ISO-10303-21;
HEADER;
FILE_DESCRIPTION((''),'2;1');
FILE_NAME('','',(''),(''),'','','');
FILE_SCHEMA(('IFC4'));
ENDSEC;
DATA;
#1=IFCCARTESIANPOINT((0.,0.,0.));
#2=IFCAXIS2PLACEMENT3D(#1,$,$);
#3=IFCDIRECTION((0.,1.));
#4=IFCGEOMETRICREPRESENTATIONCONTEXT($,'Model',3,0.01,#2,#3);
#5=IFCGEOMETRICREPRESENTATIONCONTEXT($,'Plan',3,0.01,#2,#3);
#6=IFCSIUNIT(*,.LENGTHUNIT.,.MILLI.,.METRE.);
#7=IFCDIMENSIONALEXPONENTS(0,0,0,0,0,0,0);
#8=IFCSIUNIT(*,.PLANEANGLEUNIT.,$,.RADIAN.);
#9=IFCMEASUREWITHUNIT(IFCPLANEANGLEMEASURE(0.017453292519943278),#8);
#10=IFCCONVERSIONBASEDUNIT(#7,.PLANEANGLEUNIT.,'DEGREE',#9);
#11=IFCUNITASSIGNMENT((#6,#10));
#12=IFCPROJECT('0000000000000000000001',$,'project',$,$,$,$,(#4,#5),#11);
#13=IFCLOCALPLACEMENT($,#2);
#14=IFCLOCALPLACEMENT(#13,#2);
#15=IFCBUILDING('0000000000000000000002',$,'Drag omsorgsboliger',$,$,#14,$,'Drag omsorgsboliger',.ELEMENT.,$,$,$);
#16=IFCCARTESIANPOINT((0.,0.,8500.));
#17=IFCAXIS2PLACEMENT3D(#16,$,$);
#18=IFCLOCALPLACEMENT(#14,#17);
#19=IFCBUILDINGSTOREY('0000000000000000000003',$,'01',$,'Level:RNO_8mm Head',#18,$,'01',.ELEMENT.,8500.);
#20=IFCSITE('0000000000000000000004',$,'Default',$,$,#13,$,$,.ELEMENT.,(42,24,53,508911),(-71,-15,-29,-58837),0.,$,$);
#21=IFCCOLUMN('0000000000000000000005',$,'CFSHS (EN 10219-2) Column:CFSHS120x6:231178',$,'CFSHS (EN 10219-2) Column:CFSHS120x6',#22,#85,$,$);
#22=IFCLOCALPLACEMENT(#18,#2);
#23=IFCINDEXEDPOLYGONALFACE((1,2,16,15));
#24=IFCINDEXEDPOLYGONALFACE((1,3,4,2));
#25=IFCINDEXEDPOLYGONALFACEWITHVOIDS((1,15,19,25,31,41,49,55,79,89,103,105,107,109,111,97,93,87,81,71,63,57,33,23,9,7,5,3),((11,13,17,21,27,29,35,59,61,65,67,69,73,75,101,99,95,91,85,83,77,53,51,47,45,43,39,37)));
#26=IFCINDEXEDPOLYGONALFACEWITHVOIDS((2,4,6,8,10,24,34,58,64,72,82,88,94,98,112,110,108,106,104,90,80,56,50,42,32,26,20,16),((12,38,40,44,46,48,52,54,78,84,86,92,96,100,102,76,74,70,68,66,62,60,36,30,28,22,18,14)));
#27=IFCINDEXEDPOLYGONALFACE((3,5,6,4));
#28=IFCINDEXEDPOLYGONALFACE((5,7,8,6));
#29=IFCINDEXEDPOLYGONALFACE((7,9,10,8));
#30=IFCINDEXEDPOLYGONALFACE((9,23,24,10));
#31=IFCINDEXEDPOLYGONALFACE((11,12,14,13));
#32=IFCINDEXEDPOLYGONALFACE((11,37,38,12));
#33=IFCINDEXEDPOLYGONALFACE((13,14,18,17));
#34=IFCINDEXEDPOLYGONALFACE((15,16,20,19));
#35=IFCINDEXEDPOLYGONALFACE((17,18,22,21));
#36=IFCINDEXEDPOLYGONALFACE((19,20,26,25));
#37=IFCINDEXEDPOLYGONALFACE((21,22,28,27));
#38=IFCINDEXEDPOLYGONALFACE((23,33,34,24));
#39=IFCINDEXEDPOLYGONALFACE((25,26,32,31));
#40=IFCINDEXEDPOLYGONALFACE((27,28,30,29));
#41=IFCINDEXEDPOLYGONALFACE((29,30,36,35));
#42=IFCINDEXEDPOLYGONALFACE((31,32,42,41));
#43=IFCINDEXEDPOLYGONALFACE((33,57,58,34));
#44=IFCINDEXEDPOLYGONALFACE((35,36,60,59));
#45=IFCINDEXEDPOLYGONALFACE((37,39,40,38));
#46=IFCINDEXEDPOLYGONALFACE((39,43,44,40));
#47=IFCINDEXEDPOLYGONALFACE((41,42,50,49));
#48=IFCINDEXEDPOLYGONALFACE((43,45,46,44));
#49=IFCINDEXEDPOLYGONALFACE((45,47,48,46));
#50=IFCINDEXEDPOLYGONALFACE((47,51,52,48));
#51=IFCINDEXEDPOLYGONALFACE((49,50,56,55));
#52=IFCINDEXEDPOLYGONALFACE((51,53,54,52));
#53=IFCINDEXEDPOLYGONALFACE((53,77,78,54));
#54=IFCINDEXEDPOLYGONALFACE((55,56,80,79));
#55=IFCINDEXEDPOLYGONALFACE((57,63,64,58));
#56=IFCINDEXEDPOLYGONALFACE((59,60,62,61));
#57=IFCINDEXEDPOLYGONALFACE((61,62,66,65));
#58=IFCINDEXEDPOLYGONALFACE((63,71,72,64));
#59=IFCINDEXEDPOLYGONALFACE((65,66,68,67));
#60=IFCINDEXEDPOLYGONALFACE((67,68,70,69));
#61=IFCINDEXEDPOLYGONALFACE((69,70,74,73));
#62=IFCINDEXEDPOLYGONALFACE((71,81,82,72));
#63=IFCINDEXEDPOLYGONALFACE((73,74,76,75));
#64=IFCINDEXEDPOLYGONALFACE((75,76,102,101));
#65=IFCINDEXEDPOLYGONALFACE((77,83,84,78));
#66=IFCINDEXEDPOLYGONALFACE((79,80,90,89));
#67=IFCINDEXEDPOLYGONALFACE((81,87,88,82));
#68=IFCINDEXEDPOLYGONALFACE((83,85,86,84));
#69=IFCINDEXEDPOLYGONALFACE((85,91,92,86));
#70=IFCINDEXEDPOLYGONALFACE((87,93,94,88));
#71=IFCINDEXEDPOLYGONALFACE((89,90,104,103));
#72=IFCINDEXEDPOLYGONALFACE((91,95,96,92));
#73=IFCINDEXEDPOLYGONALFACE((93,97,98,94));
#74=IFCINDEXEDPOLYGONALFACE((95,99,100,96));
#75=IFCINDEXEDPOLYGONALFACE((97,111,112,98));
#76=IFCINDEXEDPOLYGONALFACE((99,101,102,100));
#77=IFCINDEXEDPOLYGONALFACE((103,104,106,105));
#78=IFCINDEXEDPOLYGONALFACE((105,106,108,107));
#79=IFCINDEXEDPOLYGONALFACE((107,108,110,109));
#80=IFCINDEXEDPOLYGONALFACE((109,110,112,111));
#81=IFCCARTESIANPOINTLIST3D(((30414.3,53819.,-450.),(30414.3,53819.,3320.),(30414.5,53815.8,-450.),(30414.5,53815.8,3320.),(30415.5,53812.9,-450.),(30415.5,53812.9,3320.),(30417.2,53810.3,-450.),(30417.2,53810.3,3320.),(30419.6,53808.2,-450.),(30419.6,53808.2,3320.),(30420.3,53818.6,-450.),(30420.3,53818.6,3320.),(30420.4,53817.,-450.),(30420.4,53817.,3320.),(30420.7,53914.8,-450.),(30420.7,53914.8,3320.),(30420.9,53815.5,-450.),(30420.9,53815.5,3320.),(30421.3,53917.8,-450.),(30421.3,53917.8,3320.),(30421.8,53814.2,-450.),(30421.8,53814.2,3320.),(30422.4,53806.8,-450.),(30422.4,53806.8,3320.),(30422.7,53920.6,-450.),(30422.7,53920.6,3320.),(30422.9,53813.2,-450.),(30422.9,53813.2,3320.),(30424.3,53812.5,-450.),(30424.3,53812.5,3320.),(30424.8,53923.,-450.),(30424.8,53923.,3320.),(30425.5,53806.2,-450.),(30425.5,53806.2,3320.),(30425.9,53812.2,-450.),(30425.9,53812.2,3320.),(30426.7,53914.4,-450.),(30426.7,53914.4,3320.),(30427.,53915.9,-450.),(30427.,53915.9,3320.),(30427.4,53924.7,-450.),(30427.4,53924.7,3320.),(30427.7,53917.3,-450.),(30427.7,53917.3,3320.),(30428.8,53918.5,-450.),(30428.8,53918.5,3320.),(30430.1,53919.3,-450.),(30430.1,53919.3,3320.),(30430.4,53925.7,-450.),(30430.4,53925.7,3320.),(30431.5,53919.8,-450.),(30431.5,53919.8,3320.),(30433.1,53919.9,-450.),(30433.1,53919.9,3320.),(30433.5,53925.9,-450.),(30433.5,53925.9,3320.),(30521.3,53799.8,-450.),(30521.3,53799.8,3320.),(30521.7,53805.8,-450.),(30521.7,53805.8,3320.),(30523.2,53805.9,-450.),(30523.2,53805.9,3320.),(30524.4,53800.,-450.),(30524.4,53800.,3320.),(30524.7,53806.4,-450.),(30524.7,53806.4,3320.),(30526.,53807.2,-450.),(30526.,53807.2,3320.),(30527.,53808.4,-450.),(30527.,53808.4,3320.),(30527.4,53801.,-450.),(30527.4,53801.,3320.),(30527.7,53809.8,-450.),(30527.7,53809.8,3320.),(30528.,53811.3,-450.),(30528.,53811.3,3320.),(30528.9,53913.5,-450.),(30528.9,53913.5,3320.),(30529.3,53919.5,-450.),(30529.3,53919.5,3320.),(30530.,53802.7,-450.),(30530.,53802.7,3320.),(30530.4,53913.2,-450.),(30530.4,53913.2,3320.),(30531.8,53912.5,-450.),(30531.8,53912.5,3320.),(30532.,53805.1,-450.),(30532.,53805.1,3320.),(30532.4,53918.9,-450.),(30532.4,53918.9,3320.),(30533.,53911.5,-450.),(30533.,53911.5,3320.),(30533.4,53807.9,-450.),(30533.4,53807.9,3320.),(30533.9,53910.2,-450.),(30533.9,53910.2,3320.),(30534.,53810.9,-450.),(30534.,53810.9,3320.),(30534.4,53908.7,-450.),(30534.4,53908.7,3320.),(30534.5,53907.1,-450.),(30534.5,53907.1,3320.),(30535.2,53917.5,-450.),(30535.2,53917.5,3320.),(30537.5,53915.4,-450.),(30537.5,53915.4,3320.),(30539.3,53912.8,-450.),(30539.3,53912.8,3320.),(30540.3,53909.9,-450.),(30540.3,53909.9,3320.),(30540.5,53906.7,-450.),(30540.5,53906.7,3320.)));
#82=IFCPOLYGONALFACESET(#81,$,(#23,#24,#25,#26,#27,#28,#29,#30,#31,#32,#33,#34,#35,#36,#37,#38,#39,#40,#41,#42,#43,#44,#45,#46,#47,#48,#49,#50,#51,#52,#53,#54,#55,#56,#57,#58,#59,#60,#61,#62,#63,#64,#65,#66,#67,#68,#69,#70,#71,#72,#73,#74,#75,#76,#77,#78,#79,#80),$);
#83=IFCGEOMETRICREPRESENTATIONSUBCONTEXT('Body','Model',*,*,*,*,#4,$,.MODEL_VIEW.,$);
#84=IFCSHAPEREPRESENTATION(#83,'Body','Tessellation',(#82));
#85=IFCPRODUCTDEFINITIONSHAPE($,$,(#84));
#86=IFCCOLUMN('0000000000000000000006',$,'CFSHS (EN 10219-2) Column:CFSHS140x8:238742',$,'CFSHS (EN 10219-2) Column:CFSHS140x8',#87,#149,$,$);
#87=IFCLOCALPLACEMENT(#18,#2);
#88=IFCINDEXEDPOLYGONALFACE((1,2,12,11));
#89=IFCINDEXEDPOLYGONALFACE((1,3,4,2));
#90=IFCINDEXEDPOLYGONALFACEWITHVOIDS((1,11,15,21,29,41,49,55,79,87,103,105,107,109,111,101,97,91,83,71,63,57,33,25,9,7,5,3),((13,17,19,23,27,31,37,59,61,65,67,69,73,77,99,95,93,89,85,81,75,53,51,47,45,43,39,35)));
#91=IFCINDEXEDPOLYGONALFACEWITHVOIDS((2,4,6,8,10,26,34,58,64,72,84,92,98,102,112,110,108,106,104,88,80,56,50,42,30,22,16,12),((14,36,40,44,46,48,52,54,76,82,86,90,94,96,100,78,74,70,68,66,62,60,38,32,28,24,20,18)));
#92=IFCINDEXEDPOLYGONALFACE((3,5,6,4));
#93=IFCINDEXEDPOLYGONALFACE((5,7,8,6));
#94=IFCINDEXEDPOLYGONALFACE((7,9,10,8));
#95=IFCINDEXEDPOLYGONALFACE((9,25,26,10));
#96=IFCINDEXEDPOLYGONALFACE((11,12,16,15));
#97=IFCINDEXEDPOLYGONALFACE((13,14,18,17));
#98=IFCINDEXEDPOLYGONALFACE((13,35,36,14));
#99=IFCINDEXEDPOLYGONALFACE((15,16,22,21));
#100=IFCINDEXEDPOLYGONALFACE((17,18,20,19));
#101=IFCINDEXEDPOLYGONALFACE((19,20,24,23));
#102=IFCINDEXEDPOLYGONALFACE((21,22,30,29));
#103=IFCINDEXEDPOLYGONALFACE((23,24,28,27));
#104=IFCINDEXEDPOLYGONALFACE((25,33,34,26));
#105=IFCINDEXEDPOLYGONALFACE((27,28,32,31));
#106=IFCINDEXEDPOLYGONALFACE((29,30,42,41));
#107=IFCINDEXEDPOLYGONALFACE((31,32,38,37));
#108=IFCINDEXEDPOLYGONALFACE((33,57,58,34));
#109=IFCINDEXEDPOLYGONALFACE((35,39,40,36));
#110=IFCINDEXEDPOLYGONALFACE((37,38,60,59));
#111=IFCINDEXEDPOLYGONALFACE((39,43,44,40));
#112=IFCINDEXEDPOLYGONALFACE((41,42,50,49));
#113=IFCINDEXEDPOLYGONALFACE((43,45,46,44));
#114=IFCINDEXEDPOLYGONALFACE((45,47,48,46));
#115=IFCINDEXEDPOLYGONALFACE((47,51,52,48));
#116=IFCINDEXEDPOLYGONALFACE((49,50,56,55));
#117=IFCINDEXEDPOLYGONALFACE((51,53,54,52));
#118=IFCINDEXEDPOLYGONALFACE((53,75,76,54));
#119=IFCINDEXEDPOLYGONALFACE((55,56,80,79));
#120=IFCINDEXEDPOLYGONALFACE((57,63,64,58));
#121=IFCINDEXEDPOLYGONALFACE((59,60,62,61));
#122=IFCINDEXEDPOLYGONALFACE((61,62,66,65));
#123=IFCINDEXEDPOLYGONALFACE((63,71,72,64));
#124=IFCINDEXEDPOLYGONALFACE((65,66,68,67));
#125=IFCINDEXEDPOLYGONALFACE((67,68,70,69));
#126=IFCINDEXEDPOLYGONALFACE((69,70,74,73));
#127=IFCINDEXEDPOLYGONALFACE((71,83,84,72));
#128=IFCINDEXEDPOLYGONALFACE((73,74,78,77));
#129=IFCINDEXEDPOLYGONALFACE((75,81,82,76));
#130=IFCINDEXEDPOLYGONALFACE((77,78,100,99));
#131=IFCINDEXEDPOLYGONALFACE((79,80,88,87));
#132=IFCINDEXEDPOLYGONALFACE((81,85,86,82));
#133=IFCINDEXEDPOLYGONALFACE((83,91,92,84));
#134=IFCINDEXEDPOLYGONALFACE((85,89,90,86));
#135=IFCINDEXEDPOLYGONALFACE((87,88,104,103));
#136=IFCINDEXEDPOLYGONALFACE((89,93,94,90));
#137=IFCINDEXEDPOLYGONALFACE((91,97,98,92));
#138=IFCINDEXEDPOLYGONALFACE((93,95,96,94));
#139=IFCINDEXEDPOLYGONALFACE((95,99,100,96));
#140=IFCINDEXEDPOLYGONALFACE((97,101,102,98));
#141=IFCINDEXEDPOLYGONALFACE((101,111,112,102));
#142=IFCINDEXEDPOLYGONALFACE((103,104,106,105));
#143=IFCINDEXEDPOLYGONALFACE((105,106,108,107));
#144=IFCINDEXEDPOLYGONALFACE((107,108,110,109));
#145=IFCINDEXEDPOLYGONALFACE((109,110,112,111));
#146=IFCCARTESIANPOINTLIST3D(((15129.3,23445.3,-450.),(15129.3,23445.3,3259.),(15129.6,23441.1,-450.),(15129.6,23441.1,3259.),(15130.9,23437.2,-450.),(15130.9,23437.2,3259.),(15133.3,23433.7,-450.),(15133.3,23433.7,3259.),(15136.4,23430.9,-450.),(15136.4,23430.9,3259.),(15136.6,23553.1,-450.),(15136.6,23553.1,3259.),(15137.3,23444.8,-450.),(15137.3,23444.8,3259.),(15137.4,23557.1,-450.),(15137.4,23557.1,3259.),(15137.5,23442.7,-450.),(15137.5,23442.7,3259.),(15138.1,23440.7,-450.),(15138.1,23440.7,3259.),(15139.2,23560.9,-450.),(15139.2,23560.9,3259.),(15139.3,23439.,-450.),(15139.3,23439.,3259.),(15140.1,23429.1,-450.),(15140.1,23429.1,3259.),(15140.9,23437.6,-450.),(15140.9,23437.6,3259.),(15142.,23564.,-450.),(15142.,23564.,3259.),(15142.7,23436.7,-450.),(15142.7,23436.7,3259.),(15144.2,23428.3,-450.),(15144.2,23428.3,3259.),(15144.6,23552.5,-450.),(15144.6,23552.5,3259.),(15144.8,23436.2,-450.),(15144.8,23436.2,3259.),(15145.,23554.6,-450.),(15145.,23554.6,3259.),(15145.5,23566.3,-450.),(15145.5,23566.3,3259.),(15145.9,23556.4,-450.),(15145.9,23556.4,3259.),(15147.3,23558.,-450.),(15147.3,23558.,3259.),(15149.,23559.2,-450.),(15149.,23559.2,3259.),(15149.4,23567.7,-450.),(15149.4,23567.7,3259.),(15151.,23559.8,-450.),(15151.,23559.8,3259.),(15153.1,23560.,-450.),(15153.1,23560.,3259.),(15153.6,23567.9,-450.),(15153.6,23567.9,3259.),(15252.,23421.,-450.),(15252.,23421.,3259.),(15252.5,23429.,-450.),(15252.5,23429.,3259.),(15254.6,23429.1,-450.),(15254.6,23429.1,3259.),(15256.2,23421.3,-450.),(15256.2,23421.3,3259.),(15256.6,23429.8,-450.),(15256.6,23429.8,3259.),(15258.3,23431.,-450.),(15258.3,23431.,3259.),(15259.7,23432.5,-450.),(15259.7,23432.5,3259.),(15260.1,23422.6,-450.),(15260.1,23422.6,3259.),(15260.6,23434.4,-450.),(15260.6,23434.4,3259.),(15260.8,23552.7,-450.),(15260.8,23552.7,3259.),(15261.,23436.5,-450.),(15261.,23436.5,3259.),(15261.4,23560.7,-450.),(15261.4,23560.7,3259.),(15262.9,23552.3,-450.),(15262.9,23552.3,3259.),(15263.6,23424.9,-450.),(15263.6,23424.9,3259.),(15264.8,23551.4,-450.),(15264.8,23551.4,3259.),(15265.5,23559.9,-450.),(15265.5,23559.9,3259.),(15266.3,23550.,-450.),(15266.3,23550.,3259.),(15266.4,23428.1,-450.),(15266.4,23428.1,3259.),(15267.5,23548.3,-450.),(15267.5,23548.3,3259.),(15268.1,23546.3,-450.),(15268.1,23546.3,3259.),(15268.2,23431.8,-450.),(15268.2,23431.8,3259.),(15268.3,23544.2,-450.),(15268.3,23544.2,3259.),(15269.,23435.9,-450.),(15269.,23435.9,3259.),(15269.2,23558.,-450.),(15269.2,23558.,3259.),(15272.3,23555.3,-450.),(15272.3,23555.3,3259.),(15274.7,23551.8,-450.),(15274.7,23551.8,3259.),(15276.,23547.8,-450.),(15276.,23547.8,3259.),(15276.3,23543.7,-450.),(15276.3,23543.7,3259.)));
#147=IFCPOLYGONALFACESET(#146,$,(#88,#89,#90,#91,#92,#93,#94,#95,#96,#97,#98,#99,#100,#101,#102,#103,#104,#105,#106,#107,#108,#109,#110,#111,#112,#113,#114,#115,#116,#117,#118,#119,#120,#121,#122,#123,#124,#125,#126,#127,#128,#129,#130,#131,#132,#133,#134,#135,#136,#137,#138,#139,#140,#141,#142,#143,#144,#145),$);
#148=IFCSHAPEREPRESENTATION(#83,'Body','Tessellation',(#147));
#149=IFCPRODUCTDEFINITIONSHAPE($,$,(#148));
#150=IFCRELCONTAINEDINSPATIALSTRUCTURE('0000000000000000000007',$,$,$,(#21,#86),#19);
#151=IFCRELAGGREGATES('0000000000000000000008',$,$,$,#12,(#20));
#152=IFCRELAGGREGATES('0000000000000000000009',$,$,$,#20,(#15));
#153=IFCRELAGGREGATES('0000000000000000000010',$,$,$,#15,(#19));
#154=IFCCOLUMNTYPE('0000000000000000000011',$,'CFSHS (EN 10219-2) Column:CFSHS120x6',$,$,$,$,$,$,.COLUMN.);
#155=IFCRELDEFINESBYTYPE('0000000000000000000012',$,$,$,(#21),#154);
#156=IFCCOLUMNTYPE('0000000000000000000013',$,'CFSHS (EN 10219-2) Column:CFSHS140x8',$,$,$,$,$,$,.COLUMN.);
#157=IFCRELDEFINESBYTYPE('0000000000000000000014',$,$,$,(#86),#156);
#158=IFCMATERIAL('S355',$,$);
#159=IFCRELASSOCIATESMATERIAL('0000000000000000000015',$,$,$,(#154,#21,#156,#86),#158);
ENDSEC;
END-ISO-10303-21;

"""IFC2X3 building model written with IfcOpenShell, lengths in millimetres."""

from ifc_helpers import new_model, entity, si_unit, converted_unit, direction, frame, frame_2d, origin, place, context, subcontext, project, spatial, polyline, circle_curve, parameter, trimmed, segment, composite_curve, outline, extrude, source, transform, mapped, material, type_object, type_shapes, element, save


model = new_model("IFC2X3")

# Units and contexts
model_context = context("Model", 3, precision=0.01, world=origin(), true_north=direction((0.0, 1.0)))
plan_context = context("Plan", 3, precision=0.01, world=origin(), true_north=direction((0.0, 1.0)))
body_context = subcontext(model_context, "Body", "Model", "MODEL_VIEW")
ifc_project = project(units=[si_unit("LENGTHUNIT", "METRE", prefix="MILLI"), converted_unit("PLANEANGLEUNIT", "DEGREE", entity("IfcPlaneAngleMeasure", 0.017453292519943278), si_unit("PLANEANGLEUNIT", "RADIAN"), dimensions=[0, 0, 0, 0, 0, 0, 0])], contexts=[model_context, plan_context])

# Site, building, storey
site_placement = place(None, origin())
site = spatial("IfcSite", under=ifc_project, at=site_placement, Name="Default", CompositionType="ELEMENT", RefLatitude=(42, 24, 53, 508911), RefLongitude=(-71, -15, -29, -58837), RefElevation=0.0)
building_placement = place(site_placement, origin())
building = spatial("IfcBuilding", under=site, at=building_placement, Name="Drag omsorgsboliger", LongName="Drag omsorgsboliger", CompositionType="ELEMENT")
storey_placement = place(building_placement, frame((0.0, 0.0, 8500.0)))
storey = spatial("IfcBuildingStorey", under=building, at=storey_placement, Name="01", ObjectType="Level:RNO_8mm Head", LongName="01", CompositionType="ELEMENT", Elevation=8500.0)

# Columns
ifc_material = material(Name="S355")
column_type_1 = type_object("IfcColumnType", Name="CFSHS (EN 10219-2) Column:CFSHS120x6", PredefinedType="COLUMN", material=ifc_material)
shared_shape_1 = source(origin(), body_context, "Body", "SweptSolid", [
    extrude(outline(composite_curve([segment(polyline([(-48.0, -60.0), (48.0, -60.0)]), True, "CONTINUOUS"), segment(trimmed(circle_curve(frame_2d((48.0, -48.0), x_axis=(-1.0, 0.0)), 12.0), [parameter(90.0)], [parameter(180.0)], True, "PARAMETER"), True, "CONTINUOUS"), segment(polyline([(60.0, -48.0), (60.0, 48.0)]), True, "CONTINUOUS"), segment(trimmed(circle_curve(frame_2d((48.0, 48.0), x_axis=(-1.0, 0.0)), 12.0), [parameter(180.0)], [parameter(270.0)], True, "PARAMETER"), True, "CONTINUOUS"), segment(polyline([(48.0, 60.0), (-48.0, 60.0)]), True, "CONTINUOUS"), segment(trimmed(circle_curve(frame_2d((-48.0, 48.0), x_axis=(-1.0, 0.0)), 12.0), [parameter(270.0)], [parameter(360.0)], True, "PARAMETER"), True, "CONTINUOUS"), segment(polyline([(-60.0, 48.0), (-60.0, -48.0)]), True, "CONTINUOUS"), segment(trimmed(circle_curve(frame_2d((-48.0, -48.0), x_axis=(-1.0, 0.0)), 12.0), [parameter(360.0)], [parameter(90.0)], True, "PARAMETER"), True, "CONTINUOUS")], self_intersect=False), holes=[composite_curve([segment(trimmed(circle_curve(frame_2d((-48.0, -48.0), x_axis=(-1.0, 0.0)), 6.0), [parameter(360.0)], [parameter(90.0)], True, "PARAMETER"), False, "CONTINUOUS"), segment(polyline([(-54.0, -48.0), (-54.0, 48.0)]), True, "CONTINUOUS"), segment(trimmed(circle_curve(frame_2d((-48.0, 48.0), x_axis=(-1.0, 0.0)), 6.0), [parameter(270.0)], [parameter(360.0)], True, "PARAMETER"), False, "CONTINUOUS"), segment(polyline([(-48.0, 54.0), (48.0, 54.0)]), True, "CONTINUOUS"), segment(trimmed(circle_curve(frame_2d((48.0, 48.0), x_axis=(-1.0, 0.0)), 6.0), [parameter(180.0)], [parameter(270.0)], True, "PARAMETER"), False, "CONTINUOUS"), segment(polyline([(54.0, 48.0), (54.0, -48.0)]), True, "CONTINUOUS"), segment(trimmed(circle_curve(frame_2d((48.0, -48.0), x_axis=(-1.0, 0.0)), 6.0), [parameter(90.0)], [parameter(180.0)], True, "PARAMETER"), False, "CONTINUOUS"), segment(polyline([(48.0, -54.0), (-48.0, -54.0)]), True, "CONTINUOUS")], self_intersect=False)]), frame((30477.4, 53862.9, 8050.0), z_axis=(0.0, 0.0, 1.0), x_axis=(-0.997758, 0.066923, 0.0)), (0.0, 0.0, 1.0), 3770.0),
])
type_shapes(column_type_1, [shared_shape_1])
column_1_placement = place(storey_placement, frame((0.0, 0.0, -8500.0)))
element("IfcColumn", 1, at=column_1_placement, inside=storey, type_object=column_type_1, material=ifc_material, Name="CFSHS (EN 10219-2) Column:CFSHS120x6:231178", ObjectType="CFSHS (EN 10219-2) Column:CFSHS120x6", context=body_context, shape_type="MappedRepresentation", body=[
    mapped(shared_shape_1, transform((0.0, 0.0, 0.0), scale=1.0)),
])
column_type_2 = type_object("IfcColumnType", Name="CFSHS (EN 10219-2) Column:CFSHS140x8", PredefinedType="COLUMN", material=ifc_material)
shared_shape_2 = source(origin(), body_context, "Body", "SweptSolid", [
    extrude(outline(composite_curve([segment(polyline([(-54.0, -70.0), (54.0, -70.0)]), True, "CONTINUOUS"), segment(trimmed(circle_curve(frame_2d((54.0, -54.0), x_axis=(-1.0, 0.0)), 16.0), [parameter(90.0)], [parameter(180.0)], True, "PARAMETER"), True, "CONTINUOUS"), segment(polyline([(70.0, -54.0), (70.0, 54.0)]), True, "CONTINUOUS"), segment(trimmed(circle_curve(frame_2d((54.0, 54.0), x_axis=(-1.0, 0.0)), 16.0), [parameter(180.0)], [parameter(270.0)], True, "PARAMETER"), True, "CONTINUOUS"), segment(polyline([(54.0, 70.0), (-54.0, 70.0)]), True, "CONTINUOUS"), segment(trimmed(circle_curve(frame_2d((-54.0, 54.0), x_axis=(-1.0, 0.0)), 16.0), [parameter(270.0)], [parameter(360.0)], True, "PARAMETER"), True, "CONTINUOUS"), segment(polyline([(-70.0, 54.0), (-70.0, -54.0)]), True, "CONTINUOUS"), segment(trimmed(circle_curve(frame_2d((-54.0, -54.0), x_axis=(-1.0, 0.0)), 16.0), [parameter(360.0)], [parameter(90.0)], True, "PARAMETER"), True, "CONTINUOUS")], self_intersect=False), holes=[composite_curve([segment(trimmed(circle_curve(frame_2d((-54.0, -54.0), x_axis=(-1.0, 0.0)), 8.0), [parameter(360.0)], [parameter(90.0)], True, "PARAMETER"), False, "CONTINUOUS"), segment(polyline([(-62.0, -54.0), (-62.0, 54.0)]), True, "CONTINUOUS"), segment(trimmed(circle_curve(frame_2d((-54.0, 54.0), x_axis=(-1.0, 0.0)), 8.0), [parameter(270.0)], [parameter(360.0)], True, "PARAMETER"), False, "CONTINUOUS"), segment(polyline([(-54.0, 62.0), (54.0, 62.0)]), True, "CONTINUOUS"), segment(trimmed(circle_curve(frame_2d((54.0, 54.0), x_axis=(-1.0, 0.0)), 8.0), [parameter(180.0)], [parameter(270.0)], True, "PARAMETER"), False, "CONTINUOUS"), segment(polyline([(62.0, 54.0), (62.0, -54.0)]), True, "CONTINUOUS"), segment(trimmed(circle_curve(frame_2d((54.0, -54.0), x_axis=(-1.0, 0.0)), 8.0), [parameter(90.0)], [parameter(180.0)], True, "PARAMETER"), False, "CONTINUOUS"), segment(polyline([(54.0, -62.0), (-54.0, -62.0)]), True, "CONTINUOUS")], self_intersect=False)]), frame((15202.8, 23494.5, 8050.0), z_axis=(0.0, 0.0, 1.0), x_axis=(-0.997758, 0.066923, 0.0)), (0.0, 0.0, 1.0), 3709.0),
])
type_shapes(column_type_2, [shared_shape_2])
column_2_placement = place(storey_placement, frame((0.0, 0.0, -8500.0)))
element("IfcColumn", 2, at=column_2_placement, inside=storey, type_object=column_type_2, material=ifc_material, Name="CFSHS (EN 10219-2) Column:CFSHS140x8:238742", ObjectType="CFSHS (EN 10219-2) Column:CFSHS140x8", context=body_context, shape_type="MappedRepresentation", body=[
    mapped(shared_shape_2, transform((0.0, 0.0, 0.0), scale=1.0)),
])

save(model, "model.ifc")
